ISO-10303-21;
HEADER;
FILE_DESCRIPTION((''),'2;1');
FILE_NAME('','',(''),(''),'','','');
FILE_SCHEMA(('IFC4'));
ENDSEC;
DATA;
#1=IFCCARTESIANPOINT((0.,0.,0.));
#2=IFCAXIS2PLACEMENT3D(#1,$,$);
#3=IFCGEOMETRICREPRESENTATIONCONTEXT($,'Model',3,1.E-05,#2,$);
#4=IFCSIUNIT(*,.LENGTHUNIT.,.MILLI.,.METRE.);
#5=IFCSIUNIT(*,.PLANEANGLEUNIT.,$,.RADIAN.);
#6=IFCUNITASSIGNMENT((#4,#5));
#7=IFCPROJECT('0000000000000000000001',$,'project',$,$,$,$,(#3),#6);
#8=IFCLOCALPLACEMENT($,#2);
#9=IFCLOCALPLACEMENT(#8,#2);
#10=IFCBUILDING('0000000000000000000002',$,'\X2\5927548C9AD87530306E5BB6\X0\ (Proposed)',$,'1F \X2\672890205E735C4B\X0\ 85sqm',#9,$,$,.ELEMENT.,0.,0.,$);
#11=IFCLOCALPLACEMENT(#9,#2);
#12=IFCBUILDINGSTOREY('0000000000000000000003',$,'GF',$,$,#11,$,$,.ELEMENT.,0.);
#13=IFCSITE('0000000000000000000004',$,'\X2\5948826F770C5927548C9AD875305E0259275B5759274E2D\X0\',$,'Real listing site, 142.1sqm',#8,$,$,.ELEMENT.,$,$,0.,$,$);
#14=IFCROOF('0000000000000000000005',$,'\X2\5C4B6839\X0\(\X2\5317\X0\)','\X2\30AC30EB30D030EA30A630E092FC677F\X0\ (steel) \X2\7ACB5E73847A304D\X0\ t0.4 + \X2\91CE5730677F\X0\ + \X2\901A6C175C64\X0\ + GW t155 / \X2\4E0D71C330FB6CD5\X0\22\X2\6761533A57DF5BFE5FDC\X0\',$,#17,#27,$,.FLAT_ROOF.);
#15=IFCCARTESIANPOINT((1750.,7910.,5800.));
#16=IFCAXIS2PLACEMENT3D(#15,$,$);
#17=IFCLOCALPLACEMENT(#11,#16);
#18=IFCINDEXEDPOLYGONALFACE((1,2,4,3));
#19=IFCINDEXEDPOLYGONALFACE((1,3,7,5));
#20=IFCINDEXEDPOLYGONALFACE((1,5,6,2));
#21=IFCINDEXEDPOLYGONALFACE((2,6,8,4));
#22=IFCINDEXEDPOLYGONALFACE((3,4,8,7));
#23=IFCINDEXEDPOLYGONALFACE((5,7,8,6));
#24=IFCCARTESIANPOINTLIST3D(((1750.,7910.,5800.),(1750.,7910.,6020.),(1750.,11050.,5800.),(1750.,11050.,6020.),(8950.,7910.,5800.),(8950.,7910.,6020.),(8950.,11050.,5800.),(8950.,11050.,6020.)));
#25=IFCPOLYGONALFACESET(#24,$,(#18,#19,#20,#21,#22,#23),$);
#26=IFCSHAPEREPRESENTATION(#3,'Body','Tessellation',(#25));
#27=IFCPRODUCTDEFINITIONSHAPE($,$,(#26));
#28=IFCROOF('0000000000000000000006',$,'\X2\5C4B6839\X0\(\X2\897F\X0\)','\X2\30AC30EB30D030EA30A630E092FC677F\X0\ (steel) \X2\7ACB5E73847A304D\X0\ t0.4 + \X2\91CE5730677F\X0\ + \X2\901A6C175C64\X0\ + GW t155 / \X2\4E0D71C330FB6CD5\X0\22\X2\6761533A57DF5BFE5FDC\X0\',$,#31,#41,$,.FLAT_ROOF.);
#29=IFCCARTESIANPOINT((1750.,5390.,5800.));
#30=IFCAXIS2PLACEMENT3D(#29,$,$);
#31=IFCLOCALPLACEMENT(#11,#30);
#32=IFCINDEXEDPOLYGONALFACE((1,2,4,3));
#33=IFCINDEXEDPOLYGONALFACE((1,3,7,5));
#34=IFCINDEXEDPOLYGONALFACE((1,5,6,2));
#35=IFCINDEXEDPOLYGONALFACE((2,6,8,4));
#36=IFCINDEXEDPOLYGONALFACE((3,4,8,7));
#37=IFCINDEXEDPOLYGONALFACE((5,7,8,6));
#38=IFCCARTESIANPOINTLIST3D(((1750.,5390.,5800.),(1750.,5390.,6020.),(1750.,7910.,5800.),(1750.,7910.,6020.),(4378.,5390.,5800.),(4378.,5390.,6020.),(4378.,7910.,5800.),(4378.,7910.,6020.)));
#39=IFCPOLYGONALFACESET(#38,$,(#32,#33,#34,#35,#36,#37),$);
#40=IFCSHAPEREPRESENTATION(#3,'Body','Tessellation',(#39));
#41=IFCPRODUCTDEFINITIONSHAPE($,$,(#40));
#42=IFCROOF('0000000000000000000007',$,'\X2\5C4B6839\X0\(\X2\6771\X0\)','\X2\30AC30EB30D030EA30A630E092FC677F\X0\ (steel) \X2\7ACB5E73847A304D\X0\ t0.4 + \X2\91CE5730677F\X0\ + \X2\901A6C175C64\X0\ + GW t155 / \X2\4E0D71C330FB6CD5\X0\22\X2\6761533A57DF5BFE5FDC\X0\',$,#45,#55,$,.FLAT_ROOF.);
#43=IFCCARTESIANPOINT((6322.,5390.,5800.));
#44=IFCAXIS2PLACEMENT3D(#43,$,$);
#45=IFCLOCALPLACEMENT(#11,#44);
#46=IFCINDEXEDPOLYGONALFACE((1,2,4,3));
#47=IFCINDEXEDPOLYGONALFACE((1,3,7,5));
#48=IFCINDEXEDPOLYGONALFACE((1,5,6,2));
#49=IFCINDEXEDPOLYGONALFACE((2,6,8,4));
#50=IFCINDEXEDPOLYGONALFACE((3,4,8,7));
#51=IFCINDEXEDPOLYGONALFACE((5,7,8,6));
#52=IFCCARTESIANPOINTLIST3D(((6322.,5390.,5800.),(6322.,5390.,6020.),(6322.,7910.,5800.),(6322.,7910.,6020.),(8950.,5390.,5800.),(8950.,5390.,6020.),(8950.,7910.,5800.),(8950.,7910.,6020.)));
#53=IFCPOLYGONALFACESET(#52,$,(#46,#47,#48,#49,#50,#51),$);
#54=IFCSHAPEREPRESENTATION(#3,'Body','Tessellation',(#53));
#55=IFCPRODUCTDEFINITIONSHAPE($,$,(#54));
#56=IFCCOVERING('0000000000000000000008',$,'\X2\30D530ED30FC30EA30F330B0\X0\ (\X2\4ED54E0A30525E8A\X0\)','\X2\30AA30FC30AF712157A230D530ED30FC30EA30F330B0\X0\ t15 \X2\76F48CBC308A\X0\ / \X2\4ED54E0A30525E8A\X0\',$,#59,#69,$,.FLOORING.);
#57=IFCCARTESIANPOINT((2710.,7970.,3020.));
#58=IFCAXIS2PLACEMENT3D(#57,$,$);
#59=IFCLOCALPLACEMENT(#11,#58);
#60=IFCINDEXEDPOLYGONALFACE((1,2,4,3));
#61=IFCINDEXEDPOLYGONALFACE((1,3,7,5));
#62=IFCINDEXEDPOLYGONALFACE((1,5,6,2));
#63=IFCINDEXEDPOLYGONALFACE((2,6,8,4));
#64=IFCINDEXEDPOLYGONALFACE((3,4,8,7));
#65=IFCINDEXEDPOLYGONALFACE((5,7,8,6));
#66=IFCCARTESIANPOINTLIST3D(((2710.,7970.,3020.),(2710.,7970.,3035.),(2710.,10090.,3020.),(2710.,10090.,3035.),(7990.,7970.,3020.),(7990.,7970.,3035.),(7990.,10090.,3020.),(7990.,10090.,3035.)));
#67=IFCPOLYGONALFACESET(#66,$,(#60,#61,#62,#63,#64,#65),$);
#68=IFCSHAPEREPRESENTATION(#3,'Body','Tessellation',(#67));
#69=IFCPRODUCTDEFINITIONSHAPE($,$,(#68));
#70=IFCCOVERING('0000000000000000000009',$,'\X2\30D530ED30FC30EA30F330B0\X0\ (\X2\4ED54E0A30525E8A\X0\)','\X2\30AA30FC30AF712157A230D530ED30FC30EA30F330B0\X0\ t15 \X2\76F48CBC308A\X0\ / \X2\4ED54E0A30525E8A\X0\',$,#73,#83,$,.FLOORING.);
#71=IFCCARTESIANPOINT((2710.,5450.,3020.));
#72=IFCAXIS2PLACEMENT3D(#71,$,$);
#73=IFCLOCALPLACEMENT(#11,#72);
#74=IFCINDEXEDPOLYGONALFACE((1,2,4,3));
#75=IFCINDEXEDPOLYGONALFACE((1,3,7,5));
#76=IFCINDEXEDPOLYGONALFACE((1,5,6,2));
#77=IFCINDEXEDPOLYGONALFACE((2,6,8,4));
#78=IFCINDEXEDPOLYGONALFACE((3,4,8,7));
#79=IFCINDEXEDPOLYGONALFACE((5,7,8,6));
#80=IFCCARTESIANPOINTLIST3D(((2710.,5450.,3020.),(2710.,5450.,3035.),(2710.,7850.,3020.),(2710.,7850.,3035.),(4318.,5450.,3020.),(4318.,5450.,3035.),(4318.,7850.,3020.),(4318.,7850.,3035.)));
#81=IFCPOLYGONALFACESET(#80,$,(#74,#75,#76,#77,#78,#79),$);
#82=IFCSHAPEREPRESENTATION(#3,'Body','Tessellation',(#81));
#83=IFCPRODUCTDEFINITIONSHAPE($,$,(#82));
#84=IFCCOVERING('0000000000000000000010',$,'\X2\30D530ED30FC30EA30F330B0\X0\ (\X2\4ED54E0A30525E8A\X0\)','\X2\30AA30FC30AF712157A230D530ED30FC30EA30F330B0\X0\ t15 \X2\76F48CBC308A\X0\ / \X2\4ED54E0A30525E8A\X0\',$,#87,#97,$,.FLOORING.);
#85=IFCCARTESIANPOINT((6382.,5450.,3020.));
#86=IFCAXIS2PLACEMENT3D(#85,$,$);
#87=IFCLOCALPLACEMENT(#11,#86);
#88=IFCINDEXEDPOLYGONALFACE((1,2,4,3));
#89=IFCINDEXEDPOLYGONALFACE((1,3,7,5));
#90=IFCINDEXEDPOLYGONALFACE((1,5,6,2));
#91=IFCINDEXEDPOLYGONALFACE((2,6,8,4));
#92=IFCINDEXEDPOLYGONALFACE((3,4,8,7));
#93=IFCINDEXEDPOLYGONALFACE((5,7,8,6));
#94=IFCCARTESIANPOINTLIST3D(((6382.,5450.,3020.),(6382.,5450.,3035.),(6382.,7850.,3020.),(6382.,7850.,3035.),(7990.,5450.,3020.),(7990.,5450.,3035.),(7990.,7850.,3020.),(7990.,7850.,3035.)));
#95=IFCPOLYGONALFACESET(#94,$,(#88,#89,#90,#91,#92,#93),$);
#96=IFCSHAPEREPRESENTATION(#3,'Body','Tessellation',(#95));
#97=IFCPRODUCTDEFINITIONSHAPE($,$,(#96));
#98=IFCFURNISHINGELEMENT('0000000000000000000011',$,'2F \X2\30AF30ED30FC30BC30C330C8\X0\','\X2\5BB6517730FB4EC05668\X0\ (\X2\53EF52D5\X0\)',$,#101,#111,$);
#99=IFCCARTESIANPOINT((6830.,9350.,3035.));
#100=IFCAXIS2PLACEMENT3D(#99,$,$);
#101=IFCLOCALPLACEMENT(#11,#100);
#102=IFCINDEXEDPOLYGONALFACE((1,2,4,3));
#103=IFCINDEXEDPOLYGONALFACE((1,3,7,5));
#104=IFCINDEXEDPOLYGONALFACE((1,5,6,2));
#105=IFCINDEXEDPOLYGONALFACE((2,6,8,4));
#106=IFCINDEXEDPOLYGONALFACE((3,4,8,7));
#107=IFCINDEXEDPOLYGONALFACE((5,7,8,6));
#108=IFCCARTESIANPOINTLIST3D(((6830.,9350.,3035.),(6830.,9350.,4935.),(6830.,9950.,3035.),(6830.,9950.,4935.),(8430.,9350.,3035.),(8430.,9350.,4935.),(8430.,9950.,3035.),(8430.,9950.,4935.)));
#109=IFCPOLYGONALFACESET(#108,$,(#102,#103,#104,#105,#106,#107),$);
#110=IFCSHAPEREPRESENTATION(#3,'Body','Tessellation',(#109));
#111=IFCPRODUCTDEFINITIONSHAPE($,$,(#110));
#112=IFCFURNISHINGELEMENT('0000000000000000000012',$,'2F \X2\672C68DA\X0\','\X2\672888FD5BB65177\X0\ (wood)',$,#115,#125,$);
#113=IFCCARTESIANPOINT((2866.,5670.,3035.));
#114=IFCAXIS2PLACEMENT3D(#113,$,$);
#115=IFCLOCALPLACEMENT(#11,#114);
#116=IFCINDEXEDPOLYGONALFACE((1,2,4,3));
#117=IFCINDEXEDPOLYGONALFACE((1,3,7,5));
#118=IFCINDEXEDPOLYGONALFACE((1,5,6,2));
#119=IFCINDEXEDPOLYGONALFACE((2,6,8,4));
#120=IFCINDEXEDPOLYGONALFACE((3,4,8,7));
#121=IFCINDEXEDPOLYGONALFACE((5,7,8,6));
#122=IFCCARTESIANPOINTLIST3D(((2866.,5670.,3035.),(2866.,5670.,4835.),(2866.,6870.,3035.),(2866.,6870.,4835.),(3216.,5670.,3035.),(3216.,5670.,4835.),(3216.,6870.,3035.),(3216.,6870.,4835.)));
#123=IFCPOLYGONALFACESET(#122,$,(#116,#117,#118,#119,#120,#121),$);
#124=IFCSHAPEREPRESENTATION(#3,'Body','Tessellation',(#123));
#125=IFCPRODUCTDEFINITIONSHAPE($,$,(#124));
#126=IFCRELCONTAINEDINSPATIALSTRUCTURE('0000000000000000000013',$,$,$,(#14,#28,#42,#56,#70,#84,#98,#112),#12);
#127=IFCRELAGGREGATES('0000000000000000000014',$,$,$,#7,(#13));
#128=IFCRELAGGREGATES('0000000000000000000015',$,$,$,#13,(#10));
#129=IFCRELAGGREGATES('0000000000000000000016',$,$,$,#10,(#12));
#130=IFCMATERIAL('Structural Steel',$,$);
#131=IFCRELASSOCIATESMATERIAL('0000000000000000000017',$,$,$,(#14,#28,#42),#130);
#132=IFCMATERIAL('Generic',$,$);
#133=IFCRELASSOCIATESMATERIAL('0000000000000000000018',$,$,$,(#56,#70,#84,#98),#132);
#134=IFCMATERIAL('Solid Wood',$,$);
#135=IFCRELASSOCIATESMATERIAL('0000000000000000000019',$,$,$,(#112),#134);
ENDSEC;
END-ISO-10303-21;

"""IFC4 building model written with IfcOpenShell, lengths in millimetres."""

from ifc_helpers import new_model, si_unit, frame, frame_2d, origin, place, context, project, spatial, rectangle, extrude, material, element, save


model = new_model("IFC4")

# Units and contexts
model_context = context("Model", 3, precision=1e-05, world=origin())
ifc_project = project(units=[si_unit("LENGTHUNIT", "METRE", prefix="MILLI"), si_unit("PLANEANGLEUNIT", "RADIAN")], contexts=[model_context])

# Site, building, storey
site_placement = place(None, origin())
site = spatial("IfcSite", under=ifc_project, at=site_placement, Name="奈良県大和高田市大字大中", ObjectType="Real listing site, 142.1sqm", CompositionType="ELEMENT", RefElevation=0.0)
building_placement = place(site_placement, origin())
building = spatial("IfcBuilding", under=site, at=building_placement, Name="大和高田の家 (Proposed)", ObjectType="1F 木造平屋 85sqm", CompositionType="ELEMENT", ElevationOfRefHeight=0.0, ElevationOfTerrain=0.0)
storey_placement = place(building_placement, origin())
storey = spatial("IfcBuildingStorey", under=building, at=storey_placement, Name="GF", CompositionType="ELEMENT", Elevation=0.0)

# Shared definitions
ifc_material_1 = material(Name="Solid Wood")

# Shared definitions
ifc_material_2 = material(Name="Generic")

# Roofs
ifc_material_3 = material(Name="Structural Steel")
for number, where, name in (
    (1, (1750.0, 7910.0, 5800.0), "屋根(北)"),
):
    element("IfcRoof", number, at=place(storey_placement, frame(where)), inside=storey, material=ifc_material_3, Name=name, Description="ガルバリウム鋼板 (steel) 立平葺き t0.4 + 野地板 + 通気層 + GW t155 / 不燃・法22条区域対応", PredefinedType="FLAT_ROOF", context=model_context, shape_type="SweptSolid", body=[
        extrude(rectangle(XDim=7200.0, YDim=3140.0, at=frame_2d((3600.0, 1570.0))), frame((1750.0, 7910.0, 5800.0)), (0.0, 0.0, 1.0), 220.0),
    ])
roof_1_placement = place(storey_placement, frame((1750.0, 5390.0, 5800.0)))
element("IfcRoof", 2, at=roof_1_placement, inside=storey, material=ifc_material_3, Name="屋根(西)", Description="ガルバリウム鋼板 (steel) 立平葺き t0.4 + 野地板 + 通気層 + GW t155 / 不燃・法22条区域対応", PredefinedType="FLAT_ROOF", context=model_context, shape_type="SweptSolid", body=[
    extrude(rectangle(XDim=2628.0, YDim=2520.0, at=frame_2d((1314.0, 1260.0))), frame((1750.0, 5390.0, 5800.0)), (0.0, 0.0, 1.0), 220.0),
])
roof_2_placement = place(storey_placement, frame((6322.0, 5390.0, 5800.0)))
element("IfcRoof", 3, at=roof_2_placement, inside=storey, material=ifc_material_3, Name="屋根(東)", Description="ガルバリウム鋼板 (steel) 立平葺き t0.4 + 野地板 + 通気層 + GW t155 / 不燃・法22条区域対応", PredefinedType="FLAT_ROOF", context=model_context, shape_type="SweptSolid", body=[
    extrude(rectangle(XDim=2628.0, YDim=2520.0, at=frame_2d((1314.0, 1260.0))), frame((6322.0, 5390.0, 5800.0)), (0.0, 0.0, 1.0), 220.0),
])

# Coverings
covering_1_placement = place(storey_placement, frame((2710.0, 7970.0, 3020.0)))
element("IfcCovering", 4, at=covering_1_placement, inside=storey, material=ifc_material_2, Name="フローリング (仕上げ床)", Description="オーク無垢フローリング t15 直貼り / 仕上げ床", PredefinedType="FLOORING", context=model_context, shape_type="SweptSolid", body=[
    extrude(rectangle(XDim=5280.0, YDim=2120.0, at=frame_2d((2640.0, 1060.0))), frame((2710.0, 7970.0, 3020.0)), (0.0, 0.0, 1.0), 15.0),
])
covering_2_placement = place(storey_placement, frame((2710.0, 5450.0, 3020.0)))
element("IfcCovering", 5, at=covering_2_placement, inside=storey, material=ifc_material_2, Name="フローリング (仕上げ床)", Description="オーク無垢フローリング t15 直貼り / 仕上げ床", PredefinedType="FLOORING", context=model_context, shape_type="SweptSolid", body=[
    extrude(rectangle(XDim=1608.0, YDim=2400.0, at=frame_2d((804.0, 1200.0))), frame((2710.0, 5450.0, 3020.0)), (0.0, 0.0, 1.0), 15.0),
])
covering_3_placement = place(storey_placement, frame((6382.0, 5450.0, 3020.0)))
element("IfcCovering", 6, at=covering_3_placement, inside=storey, material=ifc_material_2, Name="フローリング (仕上げ床)", Description="オーク無垢フローリング t15 直貼り / 仕上げ床", PredefinedType="FLOORING", context=model_context, shape_type="SweptSolid", body=[
    extrude(rectangle(XDim=1608.0, YDim=2400.0, at=frame_2d((804.0, 1200.0))), frame((6382.0, 5450.0, 3020.0)), (0.0, 0.0, 1.0), 15.0),
])

# Furnishing elements
furnishing_1_placement = place(storey_placement, frame((6830.0, 9350.0, 3035.0)))
element("IfcFurnishingElement", 7, at=furnishing_1_placement, inside=storey, material=ifc_material_2, Name="2F クローゼット", Description="家具・什器 (可動)", context=model_context, shape_type="SweptSolid", body=[
    extrude(rectangle(XDim=1600.0, YDim=600.0, at=frame_2d((800.0, 300.0))), frame((6830.0, 9350.0, 3035.0)), (0.0, 0.0, 1.0), 1900.0),
])
furnishing_2_placement = place(storey_placement, frame((2866.0, 5670.0, 3035.0)))
element("IfcFurnishingElement", 8, at=furnishing_2_placement, inside=storey, material=ifc_material_1, Name="2F 本棚", Description="木製家具 (wood)", context=model_context, shape_type="SweptSolid", body=[
    extrude(rectangle(XDim=350.0, YDim=1200.0, at=frame_2d((175.0, 600.0))), frame((2866.0, 5670.0, 3035.0)), (0.0, 0.0, 1.0), 1800.0),
])

save(model, "model.ifc")
